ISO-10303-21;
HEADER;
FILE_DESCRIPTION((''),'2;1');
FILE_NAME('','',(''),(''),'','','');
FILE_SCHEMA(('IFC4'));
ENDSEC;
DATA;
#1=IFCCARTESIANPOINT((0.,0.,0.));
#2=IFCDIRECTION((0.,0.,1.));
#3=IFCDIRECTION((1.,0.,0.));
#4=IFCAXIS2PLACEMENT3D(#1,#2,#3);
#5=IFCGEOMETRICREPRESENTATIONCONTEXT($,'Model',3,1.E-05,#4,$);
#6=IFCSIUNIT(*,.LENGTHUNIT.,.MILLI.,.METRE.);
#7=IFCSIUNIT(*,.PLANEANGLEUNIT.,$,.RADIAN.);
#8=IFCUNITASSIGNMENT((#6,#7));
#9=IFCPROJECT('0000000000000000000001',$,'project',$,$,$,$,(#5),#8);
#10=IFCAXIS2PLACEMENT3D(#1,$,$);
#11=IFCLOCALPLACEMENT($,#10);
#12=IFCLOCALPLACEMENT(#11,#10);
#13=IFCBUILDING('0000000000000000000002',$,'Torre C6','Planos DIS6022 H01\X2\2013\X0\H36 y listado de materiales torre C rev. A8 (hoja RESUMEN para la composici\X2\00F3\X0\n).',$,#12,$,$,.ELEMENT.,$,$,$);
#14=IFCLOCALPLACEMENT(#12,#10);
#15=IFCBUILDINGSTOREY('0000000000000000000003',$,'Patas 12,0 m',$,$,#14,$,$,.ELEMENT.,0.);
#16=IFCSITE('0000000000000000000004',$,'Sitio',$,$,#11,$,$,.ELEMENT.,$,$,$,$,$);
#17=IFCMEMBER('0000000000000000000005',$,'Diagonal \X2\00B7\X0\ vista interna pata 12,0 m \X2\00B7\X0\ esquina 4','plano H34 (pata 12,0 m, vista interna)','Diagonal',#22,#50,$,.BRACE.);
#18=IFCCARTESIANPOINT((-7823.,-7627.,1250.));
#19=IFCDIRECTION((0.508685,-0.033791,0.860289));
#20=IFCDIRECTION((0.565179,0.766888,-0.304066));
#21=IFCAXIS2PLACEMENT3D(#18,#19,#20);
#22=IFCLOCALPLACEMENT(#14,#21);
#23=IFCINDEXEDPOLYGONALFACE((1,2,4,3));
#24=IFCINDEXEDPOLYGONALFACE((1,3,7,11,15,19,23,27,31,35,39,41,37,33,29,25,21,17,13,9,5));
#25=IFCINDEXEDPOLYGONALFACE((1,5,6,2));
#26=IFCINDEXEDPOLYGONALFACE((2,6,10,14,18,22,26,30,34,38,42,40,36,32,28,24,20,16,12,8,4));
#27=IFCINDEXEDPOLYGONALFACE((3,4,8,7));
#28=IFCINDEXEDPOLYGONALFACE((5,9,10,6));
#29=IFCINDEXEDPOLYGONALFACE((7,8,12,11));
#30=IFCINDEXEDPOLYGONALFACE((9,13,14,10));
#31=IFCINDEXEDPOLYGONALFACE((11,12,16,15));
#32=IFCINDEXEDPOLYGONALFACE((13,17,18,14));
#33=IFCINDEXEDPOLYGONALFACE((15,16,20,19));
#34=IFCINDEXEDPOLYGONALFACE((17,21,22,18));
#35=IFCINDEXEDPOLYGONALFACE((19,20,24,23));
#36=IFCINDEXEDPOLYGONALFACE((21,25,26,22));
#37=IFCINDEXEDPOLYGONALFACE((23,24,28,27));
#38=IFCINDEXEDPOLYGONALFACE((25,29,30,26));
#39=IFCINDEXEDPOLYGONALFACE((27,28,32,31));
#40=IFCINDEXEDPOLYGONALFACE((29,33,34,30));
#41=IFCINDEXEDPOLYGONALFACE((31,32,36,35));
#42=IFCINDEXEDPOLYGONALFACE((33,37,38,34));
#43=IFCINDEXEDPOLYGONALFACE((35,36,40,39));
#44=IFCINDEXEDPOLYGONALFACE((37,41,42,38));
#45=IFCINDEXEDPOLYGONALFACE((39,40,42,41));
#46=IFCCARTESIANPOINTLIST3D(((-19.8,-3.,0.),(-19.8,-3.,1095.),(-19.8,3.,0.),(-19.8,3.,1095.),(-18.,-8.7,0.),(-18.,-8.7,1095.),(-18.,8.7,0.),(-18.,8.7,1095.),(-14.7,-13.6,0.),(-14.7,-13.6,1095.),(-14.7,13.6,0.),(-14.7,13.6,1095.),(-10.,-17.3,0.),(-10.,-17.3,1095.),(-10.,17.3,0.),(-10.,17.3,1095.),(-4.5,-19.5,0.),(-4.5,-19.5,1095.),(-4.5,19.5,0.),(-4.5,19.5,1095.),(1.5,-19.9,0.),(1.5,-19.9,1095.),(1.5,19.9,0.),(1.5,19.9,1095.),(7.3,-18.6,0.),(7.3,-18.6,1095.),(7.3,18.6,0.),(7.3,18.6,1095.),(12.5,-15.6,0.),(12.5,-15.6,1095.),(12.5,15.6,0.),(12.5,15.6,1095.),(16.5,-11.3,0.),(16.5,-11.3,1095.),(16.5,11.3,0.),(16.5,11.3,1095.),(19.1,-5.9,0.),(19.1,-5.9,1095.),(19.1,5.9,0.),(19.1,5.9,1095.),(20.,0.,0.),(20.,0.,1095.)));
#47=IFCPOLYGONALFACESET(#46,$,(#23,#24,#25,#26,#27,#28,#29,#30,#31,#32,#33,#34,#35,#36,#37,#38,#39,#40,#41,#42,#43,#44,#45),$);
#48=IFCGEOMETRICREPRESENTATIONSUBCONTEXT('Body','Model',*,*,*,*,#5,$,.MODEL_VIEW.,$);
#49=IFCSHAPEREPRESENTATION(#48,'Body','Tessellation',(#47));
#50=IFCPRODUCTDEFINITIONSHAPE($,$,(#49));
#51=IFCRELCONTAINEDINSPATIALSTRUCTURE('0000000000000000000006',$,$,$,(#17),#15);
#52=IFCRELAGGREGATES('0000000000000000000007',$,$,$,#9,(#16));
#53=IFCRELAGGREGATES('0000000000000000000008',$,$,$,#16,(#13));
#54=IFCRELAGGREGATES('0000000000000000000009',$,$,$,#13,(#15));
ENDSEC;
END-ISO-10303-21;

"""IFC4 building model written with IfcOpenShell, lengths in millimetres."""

from ifc_helpers import new_model, si_unit, frame, origin, origin_with_axes, place, context, subcontext, project, spatial, circle, extrude, element, save


model = new_model("IFC4")

# Units and contexts
model_context = context("Model", 3, precision=1e-05, world=origin_with_axes())
body_context = subcontext(model_context, "Body", "Model", "MODEL_VIEW")
ifc_project = project(units=[si_unit("LENGTHUNIT", "METRE", prefix="MILLI"), si_unit("PLANEANGLEUNIT", "RADIAN")], contexts=[model_context])

# Site, building, storey
site_placement = place(None, origin())
site = spatial("IfcSite", under=ifc_project, at=site_placement, Name="Sitio", CompositionType="ELEMENT")
building_placement = place(site_placement, origin())
building = spatial("IfcBuilding", under=site, at=building_placement, Name="Torre C6", Description="Planos DIS6022 H01–H36 y listado de materiales torre C rev. A8 (hoja RESUMEN para la composición).", CompositionType="ELEMENT")
storey_placement = place(building_placement, origin())
storey = spatial("IfcBuildingStorey", under=building, at=storey_placement, Name="Patas 12,0 m", CompositionType="ELEMENT", Elevation=0.0)

# Member
member_1_placement = place(storey_placement, frame((-7823.0, -7627.0, 1250.0), z_axis=(0.508685, -0.033791, 0.860289), x_axis=(0.565179, 0.766888, -0.304066)))
element("IfcMember", 1, at=member_1_placement, inside=storey, Name="Diagonal · vista interna pata 12,0 m · esquina 4", Description="plano H34 (pata 12,0 m, vista interna)", ObjectType="Diagonal", PredefinedType="BRACE", context=body_context, shape_type="SweptSolid", body=[
    extrude(circle(Radius=20.0), None, (0.0, 0.0, 1.0), 1095.0),
])

save(model, "model.ifc")
